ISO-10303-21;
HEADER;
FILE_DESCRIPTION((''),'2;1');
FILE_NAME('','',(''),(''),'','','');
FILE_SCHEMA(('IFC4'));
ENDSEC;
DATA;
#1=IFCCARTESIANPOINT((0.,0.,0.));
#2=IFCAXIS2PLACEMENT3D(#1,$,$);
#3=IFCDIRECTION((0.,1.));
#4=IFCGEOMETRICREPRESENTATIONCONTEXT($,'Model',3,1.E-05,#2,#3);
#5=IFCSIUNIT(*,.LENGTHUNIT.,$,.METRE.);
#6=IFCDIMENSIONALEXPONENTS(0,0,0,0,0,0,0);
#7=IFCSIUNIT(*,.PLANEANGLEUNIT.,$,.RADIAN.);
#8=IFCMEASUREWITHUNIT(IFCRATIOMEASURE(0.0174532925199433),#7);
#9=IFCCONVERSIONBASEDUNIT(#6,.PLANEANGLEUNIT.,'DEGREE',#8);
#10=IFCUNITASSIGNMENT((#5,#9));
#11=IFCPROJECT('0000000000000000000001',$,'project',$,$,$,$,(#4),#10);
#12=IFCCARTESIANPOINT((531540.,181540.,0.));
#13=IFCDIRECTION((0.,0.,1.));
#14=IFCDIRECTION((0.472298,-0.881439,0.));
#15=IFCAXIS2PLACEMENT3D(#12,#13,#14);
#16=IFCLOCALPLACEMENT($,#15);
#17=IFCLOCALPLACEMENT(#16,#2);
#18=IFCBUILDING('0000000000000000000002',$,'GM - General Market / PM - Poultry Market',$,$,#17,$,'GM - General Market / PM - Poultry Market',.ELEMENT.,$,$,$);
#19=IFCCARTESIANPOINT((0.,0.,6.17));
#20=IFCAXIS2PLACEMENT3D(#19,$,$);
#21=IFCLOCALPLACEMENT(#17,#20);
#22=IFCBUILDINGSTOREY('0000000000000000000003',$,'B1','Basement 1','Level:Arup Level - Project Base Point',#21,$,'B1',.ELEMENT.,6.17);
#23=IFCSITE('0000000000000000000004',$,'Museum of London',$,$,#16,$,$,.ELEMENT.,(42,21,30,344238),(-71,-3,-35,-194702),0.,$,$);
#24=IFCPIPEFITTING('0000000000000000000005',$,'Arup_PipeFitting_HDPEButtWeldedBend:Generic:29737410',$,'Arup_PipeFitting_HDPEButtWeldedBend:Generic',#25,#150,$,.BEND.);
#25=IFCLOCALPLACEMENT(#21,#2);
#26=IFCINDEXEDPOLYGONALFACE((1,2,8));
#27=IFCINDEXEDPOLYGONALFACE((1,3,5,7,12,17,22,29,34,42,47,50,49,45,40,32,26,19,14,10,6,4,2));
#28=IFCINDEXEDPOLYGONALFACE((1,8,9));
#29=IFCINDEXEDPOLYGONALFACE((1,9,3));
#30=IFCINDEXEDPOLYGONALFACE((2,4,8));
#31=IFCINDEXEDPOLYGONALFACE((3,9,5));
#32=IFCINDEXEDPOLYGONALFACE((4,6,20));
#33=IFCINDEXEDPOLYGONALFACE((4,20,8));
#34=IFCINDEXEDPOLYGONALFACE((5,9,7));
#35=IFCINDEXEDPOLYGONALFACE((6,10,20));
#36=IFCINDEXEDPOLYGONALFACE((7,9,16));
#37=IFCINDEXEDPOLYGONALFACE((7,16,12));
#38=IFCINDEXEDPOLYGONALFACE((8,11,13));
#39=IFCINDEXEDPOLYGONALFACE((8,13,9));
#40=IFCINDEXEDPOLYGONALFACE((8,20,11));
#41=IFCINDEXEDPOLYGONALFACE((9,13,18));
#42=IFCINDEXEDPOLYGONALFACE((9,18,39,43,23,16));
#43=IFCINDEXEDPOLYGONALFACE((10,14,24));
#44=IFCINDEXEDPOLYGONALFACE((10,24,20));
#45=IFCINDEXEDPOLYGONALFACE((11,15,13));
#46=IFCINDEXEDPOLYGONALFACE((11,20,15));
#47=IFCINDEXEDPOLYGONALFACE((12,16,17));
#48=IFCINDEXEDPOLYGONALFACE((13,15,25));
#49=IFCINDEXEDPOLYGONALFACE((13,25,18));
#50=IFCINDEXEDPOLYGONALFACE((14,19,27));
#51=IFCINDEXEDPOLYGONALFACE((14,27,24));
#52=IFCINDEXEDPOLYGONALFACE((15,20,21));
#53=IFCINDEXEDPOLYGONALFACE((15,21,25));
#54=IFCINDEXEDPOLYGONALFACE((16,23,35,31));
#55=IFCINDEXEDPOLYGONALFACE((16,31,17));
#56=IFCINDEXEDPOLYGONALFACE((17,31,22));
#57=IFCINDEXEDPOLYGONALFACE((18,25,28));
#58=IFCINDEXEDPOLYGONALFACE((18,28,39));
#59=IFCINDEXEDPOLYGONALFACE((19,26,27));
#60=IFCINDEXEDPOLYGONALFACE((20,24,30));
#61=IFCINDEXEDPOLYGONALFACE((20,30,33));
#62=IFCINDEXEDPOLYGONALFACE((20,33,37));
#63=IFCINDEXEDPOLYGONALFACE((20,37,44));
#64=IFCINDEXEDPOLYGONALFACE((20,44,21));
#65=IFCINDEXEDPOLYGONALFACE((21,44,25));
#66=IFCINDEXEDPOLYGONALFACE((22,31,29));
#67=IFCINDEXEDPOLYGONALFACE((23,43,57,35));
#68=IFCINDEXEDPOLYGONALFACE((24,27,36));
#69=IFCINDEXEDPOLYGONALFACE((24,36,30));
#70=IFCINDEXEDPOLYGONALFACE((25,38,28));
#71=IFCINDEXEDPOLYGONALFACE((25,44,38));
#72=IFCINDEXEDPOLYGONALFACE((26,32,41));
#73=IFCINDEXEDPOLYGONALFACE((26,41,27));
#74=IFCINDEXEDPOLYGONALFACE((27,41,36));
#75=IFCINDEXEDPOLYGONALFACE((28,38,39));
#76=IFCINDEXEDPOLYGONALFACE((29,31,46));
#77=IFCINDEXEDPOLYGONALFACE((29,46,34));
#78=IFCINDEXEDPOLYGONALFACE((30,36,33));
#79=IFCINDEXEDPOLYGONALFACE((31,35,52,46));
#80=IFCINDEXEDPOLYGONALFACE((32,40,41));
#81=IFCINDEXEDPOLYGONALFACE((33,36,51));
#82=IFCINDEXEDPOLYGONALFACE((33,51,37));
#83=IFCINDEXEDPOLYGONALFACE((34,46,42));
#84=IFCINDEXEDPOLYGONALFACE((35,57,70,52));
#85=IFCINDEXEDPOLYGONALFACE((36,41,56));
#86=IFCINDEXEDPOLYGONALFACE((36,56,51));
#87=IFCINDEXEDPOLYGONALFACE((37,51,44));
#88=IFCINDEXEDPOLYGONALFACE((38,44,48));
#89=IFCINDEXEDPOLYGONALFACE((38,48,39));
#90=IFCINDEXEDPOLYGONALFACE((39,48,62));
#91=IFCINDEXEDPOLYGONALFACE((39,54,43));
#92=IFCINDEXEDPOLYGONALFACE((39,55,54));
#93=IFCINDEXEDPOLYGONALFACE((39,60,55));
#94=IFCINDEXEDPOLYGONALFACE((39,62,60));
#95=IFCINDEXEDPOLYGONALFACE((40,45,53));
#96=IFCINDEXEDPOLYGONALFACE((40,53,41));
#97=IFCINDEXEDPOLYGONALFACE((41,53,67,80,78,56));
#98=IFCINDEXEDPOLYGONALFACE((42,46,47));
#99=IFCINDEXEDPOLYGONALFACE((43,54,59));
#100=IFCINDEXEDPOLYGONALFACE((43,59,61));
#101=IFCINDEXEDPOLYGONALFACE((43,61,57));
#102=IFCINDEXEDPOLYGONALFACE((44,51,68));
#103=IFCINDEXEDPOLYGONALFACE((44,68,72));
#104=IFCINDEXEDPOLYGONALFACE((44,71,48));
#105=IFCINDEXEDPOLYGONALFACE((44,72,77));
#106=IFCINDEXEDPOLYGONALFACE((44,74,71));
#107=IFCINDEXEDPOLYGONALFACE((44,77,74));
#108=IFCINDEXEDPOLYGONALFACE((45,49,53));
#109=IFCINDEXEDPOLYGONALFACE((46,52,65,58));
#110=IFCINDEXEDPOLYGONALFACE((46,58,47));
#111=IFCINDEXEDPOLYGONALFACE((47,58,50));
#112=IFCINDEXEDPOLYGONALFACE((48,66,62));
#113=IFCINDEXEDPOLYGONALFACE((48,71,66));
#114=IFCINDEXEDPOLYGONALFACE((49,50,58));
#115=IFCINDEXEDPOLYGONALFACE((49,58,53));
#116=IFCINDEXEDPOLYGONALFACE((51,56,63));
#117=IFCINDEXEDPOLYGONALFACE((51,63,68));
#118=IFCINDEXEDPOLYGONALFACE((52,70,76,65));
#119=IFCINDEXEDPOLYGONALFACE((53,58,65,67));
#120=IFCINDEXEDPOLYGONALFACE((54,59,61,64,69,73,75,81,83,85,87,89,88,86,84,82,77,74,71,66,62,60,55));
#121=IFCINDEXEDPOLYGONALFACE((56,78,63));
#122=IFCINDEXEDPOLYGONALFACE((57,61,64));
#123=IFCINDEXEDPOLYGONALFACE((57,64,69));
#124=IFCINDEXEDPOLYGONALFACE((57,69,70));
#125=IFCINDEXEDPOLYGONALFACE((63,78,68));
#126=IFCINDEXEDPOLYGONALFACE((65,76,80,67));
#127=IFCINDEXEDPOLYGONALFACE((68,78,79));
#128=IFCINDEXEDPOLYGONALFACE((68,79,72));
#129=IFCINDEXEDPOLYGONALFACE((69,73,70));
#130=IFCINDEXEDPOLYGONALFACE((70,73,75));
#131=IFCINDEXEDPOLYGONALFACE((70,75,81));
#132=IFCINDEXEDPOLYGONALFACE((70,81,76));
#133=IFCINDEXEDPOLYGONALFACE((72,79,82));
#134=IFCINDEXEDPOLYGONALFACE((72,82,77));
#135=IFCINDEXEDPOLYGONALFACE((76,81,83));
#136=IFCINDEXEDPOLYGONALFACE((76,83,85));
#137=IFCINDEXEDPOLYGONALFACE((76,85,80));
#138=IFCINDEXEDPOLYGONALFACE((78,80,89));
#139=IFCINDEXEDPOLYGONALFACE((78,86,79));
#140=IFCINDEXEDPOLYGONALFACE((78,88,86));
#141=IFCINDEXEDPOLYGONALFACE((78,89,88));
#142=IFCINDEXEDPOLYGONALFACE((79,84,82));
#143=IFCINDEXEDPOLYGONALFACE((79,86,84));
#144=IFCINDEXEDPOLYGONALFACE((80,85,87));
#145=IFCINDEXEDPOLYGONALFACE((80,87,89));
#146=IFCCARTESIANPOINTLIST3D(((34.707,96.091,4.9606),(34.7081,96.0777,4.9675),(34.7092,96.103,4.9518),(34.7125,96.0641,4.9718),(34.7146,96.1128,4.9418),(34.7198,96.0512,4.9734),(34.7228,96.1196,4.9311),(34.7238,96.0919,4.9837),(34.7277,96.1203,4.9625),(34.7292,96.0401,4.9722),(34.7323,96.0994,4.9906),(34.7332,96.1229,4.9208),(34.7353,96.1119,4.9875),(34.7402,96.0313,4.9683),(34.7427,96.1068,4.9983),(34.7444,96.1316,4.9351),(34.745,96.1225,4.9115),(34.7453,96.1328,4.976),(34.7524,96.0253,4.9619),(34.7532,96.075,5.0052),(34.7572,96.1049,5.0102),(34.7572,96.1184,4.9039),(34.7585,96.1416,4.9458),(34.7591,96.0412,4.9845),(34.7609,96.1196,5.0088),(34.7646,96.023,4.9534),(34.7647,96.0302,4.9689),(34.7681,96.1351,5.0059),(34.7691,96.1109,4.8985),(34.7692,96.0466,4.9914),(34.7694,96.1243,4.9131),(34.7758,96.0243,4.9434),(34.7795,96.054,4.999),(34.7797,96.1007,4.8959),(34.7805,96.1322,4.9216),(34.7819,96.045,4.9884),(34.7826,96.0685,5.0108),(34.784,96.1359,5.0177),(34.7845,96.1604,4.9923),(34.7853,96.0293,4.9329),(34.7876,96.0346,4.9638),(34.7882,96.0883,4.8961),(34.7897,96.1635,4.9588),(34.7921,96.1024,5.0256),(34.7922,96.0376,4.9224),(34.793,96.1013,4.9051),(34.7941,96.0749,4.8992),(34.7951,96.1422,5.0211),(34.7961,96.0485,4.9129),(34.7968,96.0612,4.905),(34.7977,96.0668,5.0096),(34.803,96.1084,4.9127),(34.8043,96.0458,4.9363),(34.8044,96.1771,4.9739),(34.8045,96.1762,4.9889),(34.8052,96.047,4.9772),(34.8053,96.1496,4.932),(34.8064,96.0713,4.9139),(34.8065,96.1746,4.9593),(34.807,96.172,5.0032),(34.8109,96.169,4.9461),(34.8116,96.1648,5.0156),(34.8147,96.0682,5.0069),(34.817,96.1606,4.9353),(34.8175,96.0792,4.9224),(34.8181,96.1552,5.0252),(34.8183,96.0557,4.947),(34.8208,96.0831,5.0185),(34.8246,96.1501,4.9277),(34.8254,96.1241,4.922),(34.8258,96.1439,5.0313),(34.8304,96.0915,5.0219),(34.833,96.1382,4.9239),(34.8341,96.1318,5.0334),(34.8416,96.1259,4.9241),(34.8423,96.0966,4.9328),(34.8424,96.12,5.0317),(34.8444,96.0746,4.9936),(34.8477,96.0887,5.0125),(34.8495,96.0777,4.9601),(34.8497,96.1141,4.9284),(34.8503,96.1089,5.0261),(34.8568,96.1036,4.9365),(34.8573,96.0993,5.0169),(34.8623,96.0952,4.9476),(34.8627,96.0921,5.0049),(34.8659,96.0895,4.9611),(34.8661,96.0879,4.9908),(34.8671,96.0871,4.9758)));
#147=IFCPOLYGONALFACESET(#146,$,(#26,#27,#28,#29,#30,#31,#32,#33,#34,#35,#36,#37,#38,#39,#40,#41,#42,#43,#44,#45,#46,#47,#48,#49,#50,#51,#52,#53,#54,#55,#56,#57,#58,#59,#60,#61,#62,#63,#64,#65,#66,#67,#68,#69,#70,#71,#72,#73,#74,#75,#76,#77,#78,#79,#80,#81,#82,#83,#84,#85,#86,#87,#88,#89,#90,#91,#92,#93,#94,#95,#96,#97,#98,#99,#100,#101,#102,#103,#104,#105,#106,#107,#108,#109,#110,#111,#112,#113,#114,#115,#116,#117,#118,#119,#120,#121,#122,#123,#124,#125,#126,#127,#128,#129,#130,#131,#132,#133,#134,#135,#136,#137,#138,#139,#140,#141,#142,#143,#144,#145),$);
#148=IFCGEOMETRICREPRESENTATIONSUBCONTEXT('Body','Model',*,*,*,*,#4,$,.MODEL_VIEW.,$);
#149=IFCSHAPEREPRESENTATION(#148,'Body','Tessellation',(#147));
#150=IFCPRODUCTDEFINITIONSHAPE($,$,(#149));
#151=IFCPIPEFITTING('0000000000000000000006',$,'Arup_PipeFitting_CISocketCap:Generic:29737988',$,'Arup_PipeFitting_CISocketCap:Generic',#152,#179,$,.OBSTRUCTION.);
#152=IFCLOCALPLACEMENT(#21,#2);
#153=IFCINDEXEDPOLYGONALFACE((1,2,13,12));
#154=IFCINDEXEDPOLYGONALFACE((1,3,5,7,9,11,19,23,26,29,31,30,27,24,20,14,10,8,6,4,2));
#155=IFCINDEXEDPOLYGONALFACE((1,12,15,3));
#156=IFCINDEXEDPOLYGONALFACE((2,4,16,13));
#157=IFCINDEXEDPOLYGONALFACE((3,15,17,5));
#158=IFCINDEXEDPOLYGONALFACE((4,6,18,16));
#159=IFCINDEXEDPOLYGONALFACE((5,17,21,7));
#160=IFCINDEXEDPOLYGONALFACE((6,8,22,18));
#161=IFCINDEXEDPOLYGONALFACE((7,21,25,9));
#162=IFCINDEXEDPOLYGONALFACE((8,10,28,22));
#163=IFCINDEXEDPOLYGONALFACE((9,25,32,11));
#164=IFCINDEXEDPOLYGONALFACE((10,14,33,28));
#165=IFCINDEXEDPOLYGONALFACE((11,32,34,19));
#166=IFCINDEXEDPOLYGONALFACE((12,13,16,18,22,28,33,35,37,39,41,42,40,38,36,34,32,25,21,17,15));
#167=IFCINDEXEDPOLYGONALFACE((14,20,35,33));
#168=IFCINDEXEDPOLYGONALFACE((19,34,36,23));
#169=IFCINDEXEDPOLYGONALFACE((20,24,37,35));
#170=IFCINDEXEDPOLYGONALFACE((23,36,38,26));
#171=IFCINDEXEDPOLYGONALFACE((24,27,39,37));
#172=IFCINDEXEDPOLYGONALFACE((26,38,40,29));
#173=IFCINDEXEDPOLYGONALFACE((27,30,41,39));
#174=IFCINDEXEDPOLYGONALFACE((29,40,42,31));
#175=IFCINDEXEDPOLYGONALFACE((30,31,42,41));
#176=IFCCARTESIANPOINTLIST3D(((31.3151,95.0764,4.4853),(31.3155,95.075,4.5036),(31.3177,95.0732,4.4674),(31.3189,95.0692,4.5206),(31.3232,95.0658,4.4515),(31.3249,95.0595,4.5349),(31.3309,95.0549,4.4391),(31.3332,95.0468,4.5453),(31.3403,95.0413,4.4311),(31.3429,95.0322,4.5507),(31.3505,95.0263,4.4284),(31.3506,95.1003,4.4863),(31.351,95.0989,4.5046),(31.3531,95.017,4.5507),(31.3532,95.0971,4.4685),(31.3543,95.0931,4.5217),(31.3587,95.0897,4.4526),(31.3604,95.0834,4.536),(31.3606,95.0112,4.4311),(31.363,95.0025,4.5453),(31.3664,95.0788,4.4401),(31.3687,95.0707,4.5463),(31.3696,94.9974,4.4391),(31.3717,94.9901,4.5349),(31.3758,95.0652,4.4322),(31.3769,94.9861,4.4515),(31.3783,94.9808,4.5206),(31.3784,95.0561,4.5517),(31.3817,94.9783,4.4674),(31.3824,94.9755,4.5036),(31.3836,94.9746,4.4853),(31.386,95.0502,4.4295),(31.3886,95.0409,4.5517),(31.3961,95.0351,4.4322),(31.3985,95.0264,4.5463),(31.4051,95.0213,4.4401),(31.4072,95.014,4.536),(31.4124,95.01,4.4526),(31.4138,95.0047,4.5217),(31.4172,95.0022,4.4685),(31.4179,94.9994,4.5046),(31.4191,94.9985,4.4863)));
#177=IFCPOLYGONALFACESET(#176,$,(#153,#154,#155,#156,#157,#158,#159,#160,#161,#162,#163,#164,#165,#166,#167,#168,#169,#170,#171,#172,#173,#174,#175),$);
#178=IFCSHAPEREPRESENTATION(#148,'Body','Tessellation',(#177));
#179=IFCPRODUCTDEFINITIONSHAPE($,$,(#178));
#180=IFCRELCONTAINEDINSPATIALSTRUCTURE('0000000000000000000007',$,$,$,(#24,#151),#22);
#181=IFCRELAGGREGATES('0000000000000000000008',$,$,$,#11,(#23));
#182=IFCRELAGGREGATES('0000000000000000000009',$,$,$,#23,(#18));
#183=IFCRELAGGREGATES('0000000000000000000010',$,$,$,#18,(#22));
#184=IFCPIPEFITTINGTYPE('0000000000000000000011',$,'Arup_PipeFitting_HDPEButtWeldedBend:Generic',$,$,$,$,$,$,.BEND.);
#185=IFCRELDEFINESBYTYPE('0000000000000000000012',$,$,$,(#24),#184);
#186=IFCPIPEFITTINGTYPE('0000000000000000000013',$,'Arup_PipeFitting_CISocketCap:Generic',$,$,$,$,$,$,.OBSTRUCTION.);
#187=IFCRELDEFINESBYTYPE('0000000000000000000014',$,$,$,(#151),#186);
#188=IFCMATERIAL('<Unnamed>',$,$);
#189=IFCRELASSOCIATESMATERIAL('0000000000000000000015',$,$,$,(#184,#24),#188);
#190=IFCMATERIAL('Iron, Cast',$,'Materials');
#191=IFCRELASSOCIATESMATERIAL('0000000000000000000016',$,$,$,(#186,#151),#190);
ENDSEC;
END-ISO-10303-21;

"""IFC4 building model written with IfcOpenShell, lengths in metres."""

from ifc_helpers import new_model, entity, si_unit, converted_unit, direction, frame, frame_2d, origin, place, context, subcontext, project, spatial, circle, extrude, source, transform, mapped, material, type_object, type_shapes, element, save


model = new_model("IFC4")

# Units and contexts
model_context = context("Model", 3, precision=1e-05, world=origin(), true_north=direction((0.0, 1.0)))
body_context = subcontext(model_context, "Body", "Model", "MODEL_VIEW")
ifc_project = project(units=[si_unit("LENGTHUNIT", "METRE"), converted_unit("PLANEANGLEUNIT", "DEGREE", entity("IfcRatioMeasure", 0.0174532925199433), si_unit("PLANEANGLEUNIT", "RADIAN"), dimensions=[0, 0, 0, 0, 0, 0, 0])], contexts=[model_context])

# Site, building, storey
site_placement = place(None, frame((531540.0, 181540.0, 0.0), z_axis=(0.0, 0.0, 1.0), x_axis=(0.472298, -0.881439, 0.0)))
site = spatial("IfcSite", under=ifc_project, at=site_placement, Name="Museum of London", CompositionType="ELEMENT", RefLatitude=(42, 21, 30, 344238), RefLongitude=(-71, -3, -35, -194702), RefElevation=0.0)
building_placement = place(site_placement, origin())
building = spatial("IfcBuilding", under=site, at=building_placement, Name="GM - General Market / PM - Poultry Market", LongName="GM - General Market / PM - Poultry Market", CompositionType="ELEMENT")
storey_placement = place(building_placement, frame((0.0, 0.0, 6.17)))
storey = spatial("IfcBuildingStorey", under=building, at=storey_placement, Name="B1", Description="Basement 1", ObjectType="Level:Arup Level - Project Base Point", LongName="B1", CompositionType="ELEMENT", Elevation=6.17)

# Shared definitions
ifc_material_1 = material(Name="<Unnamed>")

# Pipe fittings
pipe_fitting_type_1 = type_object("IfcPipeFittingType", Name="Arup_PipeFitting_HDPEButtWeldedBend:Generic", PredefinedType="BEND", material=ifc_material_1)
ifc_direction_1 = entity("IfcDirection", [0.0, 0.0, 1.0])
trimmed_curve_1 = entity("IfcTrimmedCurve", entity("IfcCircle", entity("IfcAxis2Placement2D", entity("IfcCartesianPoint", [-0.1501, 0.0]), entity("IfcDirection", [0.0, 1.0])), 0.1501), [entity("IfcParameterValue", 270.0)], [entity("IfcParameterValue", 313.57165)], True, "PARAMETER")
shared_shape_1 = source(origin(), body_context, "Body", "AdvancedSweptSolid", [
    entity("IfcSurfaceCurveSweptAreaSolid", entity("IfcCircleProfileDef", "AREA", None, entity("IfcAxis2Placement2D", entity("IfcCartesianPoint", [0.0, 0.0]), entity("IfcDirection", [1.0, 0.0])), 0.055), entity("IfcAxis2Placement3D", entity("IfcCartesianPoint", [-0.06, 0.0, 0.0]), ifc_direction_1, entity("IfcDirection", [0.0, -1.0, 0.0])), trimmed_curve_1, 0.0, 43.5716, entity("IfcSurfaceOfLinearExtrusion", entity("IfcArbitraryOpenProfileDef", "CURVE", None, trimmed_curve_1), entity("IfcAxis2Placement3D", entity("IfcCartesianPoint", [0.0, 0.0, -0.3048])), ifc_direction_1, 1.0)),
])
type_shapes(pipe_fitting_type_1, [shared_shape_1])
pipe_fitting_1_placement = place(storey_placement, frame((34.7864, 96.0977, 4.977), z_axis=(0.572038, -0.820139, 0.011985), x_axis=(-0.819771, -0.572146, -0.024997)))
element("IfcPipeFitting", 1, at=pipe_fitting_1_placement, inside=storey, type_object=pipe_fitting_type_1, material=ifc_material_1, Name="Arup_PipeFitting_HDPEButtWeldedBend:Generic:29737410", ObjectType="Arup_PipeFitting_HDPEButtWeldedBend:Generic", PredefinedType="BEND", context=body_context, shape_type="MappedRepresentation", body=[
    mapped(shared_shape_1, transform((0.0, 0.0, 0.0), scale=1.0)),
])
ifc_material_2 = material(Name="Iron, Cast", Category="Materials")
pipe_fitting_type_2 = type_object("IfcPipeFittingType", Name="Arup_PipeFitting_CISocketCap:Generic", PredefinedType="OBSTRUCTION", material=ifc_material_2)
shared_shape_2 = source(origin(), body_context, "Body", "SweptSolid", [
    extrude(circle(Radius=0.0615, at=frame_2d((0.0, 0.0), x_axis=(1.0, 0.0))), frame((0.0, 0.0, 0.0), z_axis=(1.0, 0.0, 0.0), x_axis=(0.0, 1.0, 0.0)), (0.0, 0.0, 1.0), 0.0428),
])
type_shapes(pipe_fitting_type_2, [shared_shape_2])
pipe_fitting_2_placement = place(storey_placement, frame((31.3492, 95.0254, 4.4899), z_axis=(-0.558531, 0.829484, -0.000008), x_axis=(0.829225, 0.558357, 0.024951)))
element("IfcPipeFitting", 2, at=pipe_fitting_2_placement, inside=storey, type_object=pipe_fitting_type_2, material=ifc_material_2, Name="Arup_PipeFitting_CISocketCap:Generic:29737988", ObjectType="Arup_PipeFitting_CISocketCap:Generic", PredefinedType="OBSTRUCTION", context=body_context, shape_type="MappedRepresentation", body=[
    mapped(shared_shape_2, transform((0.0, 0.0, 0.0), scale=1.0)),
])

save(model, "model.ifc")
